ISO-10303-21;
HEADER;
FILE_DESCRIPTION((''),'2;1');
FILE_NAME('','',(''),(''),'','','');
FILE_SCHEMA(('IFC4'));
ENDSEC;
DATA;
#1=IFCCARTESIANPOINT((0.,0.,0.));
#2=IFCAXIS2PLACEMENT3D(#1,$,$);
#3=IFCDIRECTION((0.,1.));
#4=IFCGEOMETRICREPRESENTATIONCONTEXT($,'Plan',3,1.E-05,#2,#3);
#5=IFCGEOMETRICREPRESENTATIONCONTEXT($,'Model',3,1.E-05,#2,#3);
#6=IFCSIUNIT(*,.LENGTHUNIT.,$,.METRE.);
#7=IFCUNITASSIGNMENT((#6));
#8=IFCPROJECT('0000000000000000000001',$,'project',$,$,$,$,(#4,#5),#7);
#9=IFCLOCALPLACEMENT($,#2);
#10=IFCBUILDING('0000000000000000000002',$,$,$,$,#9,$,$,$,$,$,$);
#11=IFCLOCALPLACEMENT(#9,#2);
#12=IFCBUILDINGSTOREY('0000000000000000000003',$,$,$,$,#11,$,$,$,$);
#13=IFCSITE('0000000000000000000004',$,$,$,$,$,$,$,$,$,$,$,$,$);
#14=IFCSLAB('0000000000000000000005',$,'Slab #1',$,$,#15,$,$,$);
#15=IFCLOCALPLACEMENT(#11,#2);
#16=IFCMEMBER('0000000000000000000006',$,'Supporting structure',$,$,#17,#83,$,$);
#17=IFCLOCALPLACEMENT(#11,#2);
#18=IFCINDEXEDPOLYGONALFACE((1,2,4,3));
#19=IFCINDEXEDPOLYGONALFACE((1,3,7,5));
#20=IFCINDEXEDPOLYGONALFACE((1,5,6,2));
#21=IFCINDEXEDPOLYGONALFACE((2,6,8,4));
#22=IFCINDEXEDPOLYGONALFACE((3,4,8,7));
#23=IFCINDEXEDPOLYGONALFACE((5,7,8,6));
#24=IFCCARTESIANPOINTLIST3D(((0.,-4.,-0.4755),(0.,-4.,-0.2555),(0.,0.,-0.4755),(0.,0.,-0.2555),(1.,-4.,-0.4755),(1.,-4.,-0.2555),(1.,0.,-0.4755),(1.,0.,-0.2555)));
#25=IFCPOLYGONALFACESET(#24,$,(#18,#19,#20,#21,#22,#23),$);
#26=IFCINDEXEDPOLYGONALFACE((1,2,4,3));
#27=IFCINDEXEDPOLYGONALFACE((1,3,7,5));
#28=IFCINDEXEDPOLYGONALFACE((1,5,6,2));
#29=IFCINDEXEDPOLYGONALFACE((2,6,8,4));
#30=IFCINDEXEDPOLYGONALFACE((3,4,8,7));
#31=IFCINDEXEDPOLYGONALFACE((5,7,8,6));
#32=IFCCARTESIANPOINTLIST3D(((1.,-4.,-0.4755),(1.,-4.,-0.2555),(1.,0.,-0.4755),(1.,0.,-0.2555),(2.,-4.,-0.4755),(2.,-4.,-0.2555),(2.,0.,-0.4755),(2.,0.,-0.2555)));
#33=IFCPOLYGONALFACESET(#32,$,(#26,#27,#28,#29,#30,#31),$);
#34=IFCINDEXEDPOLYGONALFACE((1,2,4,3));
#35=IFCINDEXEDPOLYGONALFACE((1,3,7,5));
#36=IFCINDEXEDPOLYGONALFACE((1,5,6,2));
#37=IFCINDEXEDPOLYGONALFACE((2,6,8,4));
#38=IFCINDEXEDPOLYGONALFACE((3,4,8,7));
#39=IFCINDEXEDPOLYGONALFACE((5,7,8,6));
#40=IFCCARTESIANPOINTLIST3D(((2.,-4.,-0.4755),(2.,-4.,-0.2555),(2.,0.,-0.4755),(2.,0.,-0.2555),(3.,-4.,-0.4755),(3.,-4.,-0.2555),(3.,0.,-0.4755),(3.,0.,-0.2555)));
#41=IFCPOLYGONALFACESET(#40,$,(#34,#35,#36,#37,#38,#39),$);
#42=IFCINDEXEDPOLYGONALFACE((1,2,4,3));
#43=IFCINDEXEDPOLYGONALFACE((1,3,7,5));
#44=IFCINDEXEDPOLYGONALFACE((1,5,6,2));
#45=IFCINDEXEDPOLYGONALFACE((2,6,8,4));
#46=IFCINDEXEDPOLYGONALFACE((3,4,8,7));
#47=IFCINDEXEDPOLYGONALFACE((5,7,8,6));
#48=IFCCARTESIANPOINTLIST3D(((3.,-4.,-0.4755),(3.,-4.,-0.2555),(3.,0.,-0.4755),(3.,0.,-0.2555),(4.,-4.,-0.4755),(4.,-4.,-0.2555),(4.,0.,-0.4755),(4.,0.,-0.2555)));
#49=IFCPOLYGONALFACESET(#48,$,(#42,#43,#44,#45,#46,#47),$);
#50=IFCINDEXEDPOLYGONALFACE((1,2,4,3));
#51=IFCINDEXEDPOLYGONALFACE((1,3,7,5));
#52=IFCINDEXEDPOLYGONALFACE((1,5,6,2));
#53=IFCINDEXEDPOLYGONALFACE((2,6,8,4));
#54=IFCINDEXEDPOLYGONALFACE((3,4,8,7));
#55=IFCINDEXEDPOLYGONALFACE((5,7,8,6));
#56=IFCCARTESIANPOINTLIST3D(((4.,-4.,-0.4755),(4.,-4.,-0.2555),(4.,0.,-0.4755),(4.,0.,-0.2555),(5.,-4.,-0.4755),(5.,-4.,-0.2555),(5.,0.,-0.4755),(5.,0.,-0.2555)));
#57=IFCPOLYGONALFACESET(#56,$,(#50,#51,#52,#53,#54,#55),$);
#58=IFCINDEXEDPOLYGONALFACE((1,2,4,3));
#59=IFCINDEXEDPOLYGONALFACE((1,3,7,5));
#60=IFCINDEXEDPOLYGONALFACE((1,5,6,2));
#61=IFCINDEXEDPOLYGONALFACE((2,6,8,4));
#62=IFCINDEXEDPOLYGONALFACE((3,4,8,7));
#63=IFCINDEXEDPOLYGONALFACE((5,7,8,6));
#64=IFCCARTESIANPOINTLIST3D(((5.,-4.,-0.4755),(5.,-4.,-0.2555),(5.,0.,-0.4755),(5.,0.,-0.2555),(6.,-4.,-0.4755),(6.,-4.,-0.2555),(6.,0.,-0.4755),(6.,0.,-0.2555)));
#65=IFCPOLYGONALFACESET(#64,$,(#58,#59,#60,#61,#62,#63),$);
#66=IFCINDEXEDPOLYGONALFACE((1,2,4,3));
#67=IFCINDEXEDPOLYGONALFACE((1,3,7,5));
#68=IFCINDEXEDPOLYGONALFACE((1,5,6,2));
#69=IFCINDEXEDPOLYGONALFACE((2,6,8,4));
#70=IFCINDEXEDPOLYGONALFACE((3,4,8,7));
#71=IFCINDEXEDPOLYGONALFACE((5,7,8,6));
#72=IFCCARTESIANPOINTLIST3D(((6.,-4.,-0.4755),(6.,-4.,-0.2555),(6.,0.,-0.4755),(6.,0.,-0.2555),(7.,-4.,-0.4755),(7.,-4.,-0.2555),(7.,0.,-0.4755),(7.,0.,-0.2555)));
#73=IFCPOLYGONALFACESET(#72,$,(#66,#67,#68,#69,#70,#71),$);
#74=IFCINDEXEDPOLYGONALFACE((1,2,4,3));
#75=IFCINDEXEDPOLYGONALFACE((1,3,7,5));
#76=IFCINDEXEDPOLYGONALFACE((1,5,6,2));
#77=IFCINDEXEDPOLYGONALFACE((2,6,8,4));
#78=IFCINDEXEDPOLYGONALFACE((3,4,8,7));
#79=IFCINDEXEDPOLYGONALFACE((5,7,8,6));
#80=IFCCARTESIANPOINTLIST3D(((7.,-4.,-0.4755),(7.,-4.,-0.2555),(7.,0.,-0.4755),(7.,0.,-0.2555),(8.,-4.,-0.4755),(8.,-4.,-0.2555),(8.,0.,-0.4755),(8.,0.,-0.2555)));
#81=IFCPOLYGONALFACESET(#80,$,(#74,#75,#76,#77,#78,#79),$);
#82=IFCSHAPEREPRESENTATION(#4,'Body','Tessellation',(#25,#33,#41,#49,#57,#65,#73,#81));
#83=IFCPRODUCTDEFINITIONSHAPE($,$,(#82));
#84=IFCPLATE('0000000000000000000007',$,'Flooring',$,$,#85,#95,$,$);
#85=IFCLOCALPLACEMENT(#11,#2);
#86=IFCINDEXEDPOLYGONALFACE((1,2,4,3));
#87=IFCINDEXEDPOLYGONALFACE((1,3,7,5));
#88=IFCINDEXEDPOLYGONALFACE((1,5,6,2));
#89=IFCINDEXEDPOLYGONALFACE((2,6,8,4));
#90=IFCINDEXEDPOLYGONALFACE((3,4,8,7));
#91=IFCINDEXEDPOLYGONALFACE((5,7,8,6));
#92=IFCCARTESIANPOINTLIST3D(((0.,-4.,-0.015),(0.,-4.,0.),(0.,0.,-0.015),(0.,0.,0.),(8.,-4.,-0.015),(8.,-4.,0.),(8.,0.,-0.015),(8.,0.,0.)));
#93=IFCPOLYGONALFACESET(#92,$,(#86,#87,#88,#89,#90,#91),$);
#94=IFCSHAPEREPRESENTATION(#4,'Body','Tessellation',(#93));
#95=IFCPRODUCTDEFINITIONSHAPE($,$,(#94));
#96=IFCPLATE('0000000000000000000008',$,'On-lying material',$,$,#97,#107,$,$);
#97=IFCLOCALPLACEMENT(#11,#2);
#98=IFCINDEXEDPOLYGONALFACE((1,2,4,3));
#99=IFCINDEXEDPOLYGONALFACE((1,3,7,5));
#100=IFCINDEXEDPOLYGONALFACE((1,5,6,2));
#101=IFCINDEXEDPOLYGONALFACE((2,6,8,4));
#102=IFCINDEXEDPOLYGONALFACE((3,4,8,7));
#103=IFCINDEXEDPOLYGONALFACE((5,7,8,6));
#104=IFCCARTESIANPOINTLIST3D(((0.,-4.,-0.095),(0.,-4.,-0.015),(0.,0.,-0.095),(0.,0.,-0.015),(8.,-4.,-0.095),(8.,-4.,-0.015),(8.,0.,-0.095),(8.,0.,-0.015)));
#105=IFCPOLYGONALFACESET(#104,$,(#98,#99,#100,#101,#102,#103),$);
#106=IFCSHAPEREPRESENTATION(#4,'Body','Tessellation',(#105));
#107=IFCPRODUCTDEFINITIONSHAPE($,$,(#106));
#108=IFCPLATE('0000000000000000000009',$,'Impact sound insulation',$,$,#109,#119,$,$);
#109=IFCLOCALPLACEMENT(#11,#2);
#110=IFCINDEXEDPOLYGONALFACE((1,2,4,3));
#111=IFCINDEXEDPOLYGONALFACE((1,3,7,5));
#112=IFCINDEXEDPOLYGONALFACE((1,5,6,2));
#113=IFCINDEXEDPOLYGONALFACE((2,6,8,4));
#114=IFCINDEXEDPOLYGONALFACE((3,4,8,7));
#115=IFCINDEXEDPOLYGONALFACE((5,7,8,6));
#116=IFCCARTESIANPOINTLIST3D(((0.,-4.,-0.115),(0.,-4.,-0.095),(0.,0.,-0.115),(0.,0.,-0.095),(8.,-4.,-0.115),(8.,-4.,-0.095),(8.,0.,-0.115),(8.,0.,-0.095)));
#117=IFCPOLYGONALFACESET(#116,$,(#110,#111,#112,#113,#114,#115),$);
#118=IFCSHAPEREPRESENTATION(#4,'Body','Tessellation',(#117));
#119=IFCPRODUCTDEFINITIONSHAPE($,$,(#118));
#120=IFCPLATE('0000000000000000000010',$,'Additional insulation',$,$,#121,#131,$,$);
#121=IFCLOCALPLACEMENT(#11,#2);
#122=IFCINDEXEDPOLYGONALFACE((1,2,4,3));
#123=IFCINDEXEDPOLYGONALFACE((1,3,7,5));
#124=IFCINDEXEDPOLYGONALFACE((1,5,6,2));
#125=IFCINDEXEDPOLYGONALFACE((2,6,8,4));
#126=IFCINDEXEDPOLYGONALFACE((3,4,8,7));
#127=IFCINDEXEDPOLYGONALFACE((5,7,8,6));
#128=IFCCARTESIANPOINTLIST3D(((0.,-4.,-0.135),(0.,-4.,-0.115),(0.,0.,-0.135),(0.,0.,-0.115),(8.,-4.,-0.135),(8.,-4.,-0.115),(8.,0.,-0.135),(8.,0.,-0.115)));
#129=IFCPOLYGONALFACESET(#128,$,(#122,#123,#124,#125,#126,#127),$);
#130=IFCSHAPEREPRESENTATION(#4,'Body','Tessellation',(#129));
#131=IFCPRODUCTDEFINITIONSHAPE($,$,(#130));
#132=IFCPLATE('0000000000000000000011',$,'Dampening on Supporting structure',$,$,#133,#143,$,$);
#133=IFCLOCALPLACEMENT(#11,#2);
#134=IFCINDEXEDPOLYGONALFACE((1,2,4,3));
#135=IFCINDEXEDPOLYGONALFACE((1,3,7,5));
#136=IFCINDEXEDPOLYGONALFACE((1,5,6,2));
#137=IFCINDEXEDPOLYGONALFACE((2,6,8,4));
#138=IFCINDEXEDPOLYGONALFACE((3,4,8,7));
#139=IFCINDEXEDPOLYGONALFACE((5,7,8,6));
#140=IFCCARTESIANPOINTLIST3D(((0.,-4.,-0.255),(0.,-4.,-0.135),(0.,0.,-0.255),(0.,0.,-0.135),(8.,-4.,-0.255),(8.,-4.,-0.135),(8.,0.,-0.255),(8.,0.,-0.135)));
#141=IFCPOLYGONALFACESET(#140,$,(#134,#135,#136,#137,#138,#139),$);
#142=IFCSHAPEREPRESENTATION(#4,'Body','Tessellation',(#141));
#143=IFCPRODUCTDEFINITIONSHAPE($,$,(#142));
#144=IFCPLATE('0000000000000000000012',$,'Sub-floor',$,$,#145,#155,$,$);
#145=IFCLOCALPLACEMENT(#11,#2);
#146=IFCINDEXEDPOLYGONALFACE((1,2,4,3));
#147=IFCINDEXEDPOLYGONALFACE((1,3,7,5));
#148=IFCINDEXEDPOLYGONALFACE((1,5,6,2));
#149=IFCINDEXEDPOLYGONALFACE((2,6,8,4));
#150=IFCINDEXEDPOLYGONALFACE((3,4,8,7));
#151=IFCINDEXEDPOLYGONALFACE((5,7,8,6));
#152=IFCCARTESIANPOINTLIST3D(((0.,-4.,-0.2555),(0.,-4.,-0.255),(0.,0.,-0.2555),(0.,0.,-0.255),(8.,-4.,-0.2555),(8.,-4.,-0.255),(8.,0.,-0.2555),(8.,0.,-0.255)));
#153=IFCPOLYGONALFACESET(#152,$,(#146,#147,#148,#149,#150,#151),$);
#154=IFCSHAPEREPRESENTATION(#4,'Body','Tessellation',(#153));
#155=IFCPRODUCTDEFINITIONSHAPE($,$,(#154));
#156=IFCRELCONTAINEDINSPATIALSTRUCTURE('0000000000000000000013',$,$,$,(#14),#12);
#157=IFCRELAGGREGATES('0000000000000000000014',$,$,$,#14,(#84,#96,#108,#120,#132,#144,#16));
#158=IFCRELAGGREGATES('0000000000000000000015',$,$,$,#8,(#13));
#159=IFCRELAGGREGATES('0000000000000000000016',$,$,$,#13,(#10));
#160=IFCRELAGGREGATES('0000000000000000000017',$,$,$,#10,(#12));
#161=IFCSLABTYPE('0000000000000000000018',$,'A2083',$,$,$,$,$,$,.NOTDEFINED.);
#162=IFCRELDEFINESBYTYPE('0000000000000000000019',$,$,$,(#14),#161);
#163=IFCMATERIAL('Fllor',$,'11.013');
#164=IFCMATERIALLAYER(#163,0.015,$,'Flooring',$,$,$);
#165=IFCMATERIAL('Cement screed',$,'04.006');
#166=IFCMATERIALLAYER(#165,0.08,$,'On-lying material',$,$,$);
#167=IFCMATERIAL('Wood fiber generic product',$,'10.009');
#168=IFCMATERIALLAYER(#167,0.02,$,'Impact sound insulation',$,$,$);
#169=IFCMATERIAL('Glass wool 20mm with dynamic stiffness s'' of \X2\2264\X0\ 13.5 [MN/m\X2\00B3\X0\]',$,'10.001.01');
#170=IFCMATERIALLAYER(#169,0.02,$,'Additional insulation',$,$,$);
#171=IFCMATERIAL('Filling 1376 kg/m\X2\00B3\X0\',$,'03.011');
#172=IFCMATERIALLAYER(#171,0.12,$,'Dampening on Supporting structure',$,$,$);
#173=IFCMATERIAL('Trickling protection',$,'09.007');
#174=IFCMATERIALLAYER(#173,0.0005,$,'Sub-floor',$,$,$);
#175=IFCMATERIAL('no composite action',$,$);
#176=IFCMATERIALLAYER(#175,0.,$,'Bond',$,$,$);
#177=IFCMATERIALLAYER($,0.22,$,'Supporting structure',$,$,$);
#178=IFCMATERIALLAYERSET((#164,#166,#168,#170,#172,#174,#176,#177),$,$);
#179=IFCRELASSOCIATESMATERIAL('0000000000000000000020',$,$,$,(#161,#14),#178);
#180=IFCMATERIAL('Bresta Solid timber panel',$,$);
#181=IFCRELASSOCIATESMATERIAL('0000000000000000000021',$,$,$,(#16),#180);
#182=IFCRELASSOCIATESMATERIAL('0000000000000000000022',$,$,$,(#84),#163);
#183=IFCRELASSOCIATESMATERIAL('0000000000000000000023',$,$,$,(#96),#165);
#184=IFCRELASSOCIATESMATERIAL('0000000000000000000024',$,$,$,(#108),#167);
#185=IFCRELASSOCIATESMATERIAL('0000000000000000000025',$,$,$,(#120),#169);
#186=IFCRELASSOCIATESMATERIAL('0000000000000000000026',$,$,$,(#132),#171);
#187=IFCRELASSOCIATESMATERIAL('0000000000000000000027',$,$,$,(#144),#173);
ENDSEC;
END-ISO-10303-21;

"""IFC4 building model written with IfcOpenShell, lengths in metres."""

from ifc_helpers import new_model, si_unit, direction, frame, frame_2d, origin, origin_with_axes, place, context, project, spatial, rectangle, extrude, material, layer, layer_set, type_object, element, aggregate, save


model = new_model("IFC4")

# Units and contexts
plan_context = context("Plan", 3, precision=1e-05, world=origin(), true_north=direction((0.0, 1.0)))
model_context = context("Model", 3, precision=1e-05, world=origin(), true_north=direction((0.0, 1.0)))
ifc_project = project(units=[si_unit("LENGTHUNIT", "METRE")], contexts=[plan_context, model_context])

# Site, building, storey
site = spatial("IfcSite", under=ifc_project)
building_placement = place(None, origin())
building = spatial("IfcBuilding", under=site, at=building_placement)
storey_placement = place(building_placement, origin())
storey = spatial("IfcBuildingStorey", under=building, at=storey_placement)

# Slab, member, plates
ifc_material_1 = material(Name="Fllor", Category="11.013")
ifc_layer_1 = layer(ifc_material_1, 0.015, Name="Flooring")
ifc_material_2 = material(Name="Cement screed", Category="04.006")
ifc_layer_2 = layer(ifc_material_2, 0.08, Name="On-lying material")
ifc_material_3 = material(Name="Wood fiber generic product", Category="10.009")
ifc_layer_3 = layer(ifc_material_3, 0.02, Name="Impact sound insulation")
ifc_material_4 = material(Name="Glass wool 20mm with dynamic stiffness s' of ≤ 13.5 [MN/m³]", Category="10.001.01")
ifc_layer_4 = layer(ifc_material_4, 0.02, Name="Additional insulation")
ifc_material_5 = material(Name="Filling 1376 kg/m³", Category="03.011")
ifc_layer_5 = layer(ifc_material_5, 0.12, Name="Dampening on Supporting structure")
ifc_material_6 = material(Name="Trickling protection", Category="09.007")
ifc_layer_6 = layer(ifc_material_6, 0.0005, Name="Sub-floor")
ifc_material_7 = material(Name="no composite action")
ifc_layer_7 = layer(ifc_material_7, 0.0, Name="Bond")
ifc_layer_8 = layer(None, 0.22, Name="Supporting structure")
ifc_layer_set = layer_set([ifc_layer_1, ifc_layer_2, ifc_layer_3, ifc_layer_4, ifc_layer_5, ifc_layer_6, ifc_layer_7, ifc_layer_8])
slab_type = type_object("IfcSlabType", Name="A2083", PredefinedType="NOTDEFINED", material=ifc_layer_set)
slab_placement = place(None, frame((0.0, 0.0, 0.0), z_axis=(0.0, 0.0, -1.0), x_axis=(1.0, 0.0, 0.0)))
slab = element("IfcSlab", 1, at=slab_placement, inside=storey, type_object=slab_type, material=ifc_layer_set, Name="Slab #1")
ifc_material_8 = material(Name="Bresta Solid timber panel")
member_placement = place(slab_placement, origin())
member = element("IfcMember", 2, at=member_placement, material=ifc_material_8, Name="Supporting structure", context=plan_context, shape_type="SweptSolid", body=[
    extrude(rectangle(XDim=1.0, YDim=0.22, at=frame_2d((0.5, 0.11), x_axis=(1.0, 0.0))), frame((0.0, 4.0, 0.2555), z_axis=(0.0, -1.0, 0.0), x_axis=(1.0, 0.0, 0.0)), (0.0, 0.0, 1.0), 4.0),
    extrude(rectangle(XDim=1.0, YDim=0.22, at=frame_2d((0.5, 0.11), x_axis=(1.0, 0.0))), frame((1.0, 4.0, 0.2555), z_axis=(0.0, -1.0, 0.0), x_axis=(1.0, 0.0, 0.0)), (0.0, 0.0, 1.0), 4.0),
    extrude(rectangle(XDim=1.0, YDim=0.22, at=frame_2d((0.5, 0.11), x_axis=(1.0, 0.0))), frame((2.0, 4.0, 0.2555), z_axis=(0.0, -1.0, 0.0), x_axis=(1.0, 0.0, 0.0)), (0.0, 0.0, 1.0), 4.0),
    extrude(rectangle(XDim=1.0, YDim=0.22, at=frame_2d((0.5, 0.11), x_axis=(1.0, 0.0))), frame((3.0, 4.0, 0.2555), z_axis=(0.0, -1.0, 0.0), x_axis=(1.0, 0.0, 0.0)), (0.0, 0.0, 1.0), 4.0),
    extrude(rectangle(XDim=1.0, YDim=0.22, at=frame_2d((0.5, 0.11), x_axis=(1.0, 0.0))), frame((4.0, 4.0, 0.2555), z_axis=(0.0, -1.0, 0.0), x_axis=(1.0, 0.0, 0.0)), (0.0, 0.0, 1.0), 4.0),
    extrude(rectangle(XDim=1.0, YDim=0.22, at=frame_2d((0.5, 0.11), x_axis=(1.0, 0.0))), frame((5.0, 4.0, 0.2555), z_axis=(0.0, -1.0, 0.0), x_axis=(1.0, 0.0, 0.0)), (0.0, 0.0, 1.0), 4.0),
    extrude(rectangle(XDim=1.0, YDim=0.22, at=frame_2d((0.5, 0.11), x_axis=(1.0, 0.0))), frame((6.0, 4.0, 0.2555), z_axis=(0.0, -1.0, 0.0), x_axis=(1.0, 0.0, 0.0)), (0.0, 0.0, 1.0), 4.0),
    extrude(rectangle(XDim=1.0, YDim=0.22, at=frame_2d((0.5, 0.11), x_axis=(1.0, 0.0))), frame((7.0, 4.0, 0.2555), z_axis=(0.0, -1.0, 0.0), x_axis=(1.0, 0.0, 0.0)), (0.0, 0.0, 1.0), 4.0),
])
plate_1_placement = place(slab_placement, origin())
plate_1 = element("IfcPlate", 3, at=plate_1_placement, material=ifc_material_1, Name="Flooring", context=plan_context, shape_type="SweptSolid", body=[
    extrude(rectangle(XDim=8.0, YDim=4.0, at=frame_2d((4.0, 2.0), x_axis=(1.0, 0.0))), origin_with_axes(), (0.0, 0.0, 1.0), 0.015),
])
plate_2_placement = place(slab_placement, origin())
plate_2 = element("IfcPlate", 4, at=plate_2_placement, material=ifc_material_2, Name="On-lying material", context=plan_context, shape_type="SweptSolid", body=[
    extrude(rectangle(XDim=8.0, YDim=4.0, at=frame_2d((4.0, 2.0), x_axis=(1.0, 0.0))), frame((0.0, 0.0, 0.015), z_axis=(0.0, 0.0, 1.0), x_axis=(1.0, 0.0, 0.0)), (0.0, 0.0, 1.0), 0.08),
])
plate_3_placement = place(slab_placement, origin())
plate_3 = element("IfcPlate", 5, at=plate_3_placement, material=ifc_material_3, Name="Impact sound insulation", context=plan_context, shape_type="SweptSolid", body=[
    extrude(rectangle(XDim=8.0, YDim=4.0, at=frame_2d((4.0, 2.0), x_axis=(1.0, 0.0))), frame((0.0, 0.0, 0.095), z_axis=(0.0, 0.0, 1.0), x_axis=(1.0, 0.0, 0.0)), (0.0, 0.0, 1.0), 0.02),
])
plate_4_placement = place(slab_placement, origin())
plate_4 = element("IfcPlate", 6, at=plate_4_placement, material=ifc_material_4, Name="Additional insulation", context=plan_context, shape_type="SweptSolid", body=[
    extrude(rectangle(XDim=8.0, YDim=4.0, at=frame_2d((4.0, 2.0), x_axis=(1.0, 0.0))), frame((0.0, 0.0, 0.115), z_axis=(0.0, 0.0, 1.0), x_axis=(1.0, 0.0, 0.0)), (0.0, 0.0, 1.0), 0.02),
])
plate_5_placement = place(slab_placement, origin())
plate_5 = element("IfcPlate", 7, at=plate_5_placement, material=ifc_material_5, Name="Dampening on Supporting structure", context=plan_context, shape_type="SweptSolid", body=[
    extrude(rectangle(XDim=8.0, YDim=4.0, at=frame_2d((4.0, 2.0), x_axis=(1.0, 0.0))), frame((0.0, 0.0, 0.135), z_axis=(0.0, 0.0, 1.0), x_axis=(1.0, 0.0, 0.0)), (0.0, 0.0, 1.0), 0.12),
])
plate_6_placement = place(slab_placement, origin())
plate_6 = element("IfcPlate", 8, at=plate_6_placement, material=ifc_material_6, Name="Sub-floor", context=plan_context, shape_type="SweptSolid", body=[
    extrude(rectangle(XDim=8.0, YDim=4.0, at=frame_2d((4.0, 2.0), x_axis=(1.0, 0.0))), frame((0.0, 0.0, 0.255), z_axis=(0.0, 0.0, 1.0), x_axis=(1.0, 0.0, 0.0)), (0.0, 0.0, 1.0), 0.0005),
])
aggregate(slab, [plate_1, plate_2, plate_3, plate_4, plate_5, plate_6, member])

save(model, "model.ifc")
